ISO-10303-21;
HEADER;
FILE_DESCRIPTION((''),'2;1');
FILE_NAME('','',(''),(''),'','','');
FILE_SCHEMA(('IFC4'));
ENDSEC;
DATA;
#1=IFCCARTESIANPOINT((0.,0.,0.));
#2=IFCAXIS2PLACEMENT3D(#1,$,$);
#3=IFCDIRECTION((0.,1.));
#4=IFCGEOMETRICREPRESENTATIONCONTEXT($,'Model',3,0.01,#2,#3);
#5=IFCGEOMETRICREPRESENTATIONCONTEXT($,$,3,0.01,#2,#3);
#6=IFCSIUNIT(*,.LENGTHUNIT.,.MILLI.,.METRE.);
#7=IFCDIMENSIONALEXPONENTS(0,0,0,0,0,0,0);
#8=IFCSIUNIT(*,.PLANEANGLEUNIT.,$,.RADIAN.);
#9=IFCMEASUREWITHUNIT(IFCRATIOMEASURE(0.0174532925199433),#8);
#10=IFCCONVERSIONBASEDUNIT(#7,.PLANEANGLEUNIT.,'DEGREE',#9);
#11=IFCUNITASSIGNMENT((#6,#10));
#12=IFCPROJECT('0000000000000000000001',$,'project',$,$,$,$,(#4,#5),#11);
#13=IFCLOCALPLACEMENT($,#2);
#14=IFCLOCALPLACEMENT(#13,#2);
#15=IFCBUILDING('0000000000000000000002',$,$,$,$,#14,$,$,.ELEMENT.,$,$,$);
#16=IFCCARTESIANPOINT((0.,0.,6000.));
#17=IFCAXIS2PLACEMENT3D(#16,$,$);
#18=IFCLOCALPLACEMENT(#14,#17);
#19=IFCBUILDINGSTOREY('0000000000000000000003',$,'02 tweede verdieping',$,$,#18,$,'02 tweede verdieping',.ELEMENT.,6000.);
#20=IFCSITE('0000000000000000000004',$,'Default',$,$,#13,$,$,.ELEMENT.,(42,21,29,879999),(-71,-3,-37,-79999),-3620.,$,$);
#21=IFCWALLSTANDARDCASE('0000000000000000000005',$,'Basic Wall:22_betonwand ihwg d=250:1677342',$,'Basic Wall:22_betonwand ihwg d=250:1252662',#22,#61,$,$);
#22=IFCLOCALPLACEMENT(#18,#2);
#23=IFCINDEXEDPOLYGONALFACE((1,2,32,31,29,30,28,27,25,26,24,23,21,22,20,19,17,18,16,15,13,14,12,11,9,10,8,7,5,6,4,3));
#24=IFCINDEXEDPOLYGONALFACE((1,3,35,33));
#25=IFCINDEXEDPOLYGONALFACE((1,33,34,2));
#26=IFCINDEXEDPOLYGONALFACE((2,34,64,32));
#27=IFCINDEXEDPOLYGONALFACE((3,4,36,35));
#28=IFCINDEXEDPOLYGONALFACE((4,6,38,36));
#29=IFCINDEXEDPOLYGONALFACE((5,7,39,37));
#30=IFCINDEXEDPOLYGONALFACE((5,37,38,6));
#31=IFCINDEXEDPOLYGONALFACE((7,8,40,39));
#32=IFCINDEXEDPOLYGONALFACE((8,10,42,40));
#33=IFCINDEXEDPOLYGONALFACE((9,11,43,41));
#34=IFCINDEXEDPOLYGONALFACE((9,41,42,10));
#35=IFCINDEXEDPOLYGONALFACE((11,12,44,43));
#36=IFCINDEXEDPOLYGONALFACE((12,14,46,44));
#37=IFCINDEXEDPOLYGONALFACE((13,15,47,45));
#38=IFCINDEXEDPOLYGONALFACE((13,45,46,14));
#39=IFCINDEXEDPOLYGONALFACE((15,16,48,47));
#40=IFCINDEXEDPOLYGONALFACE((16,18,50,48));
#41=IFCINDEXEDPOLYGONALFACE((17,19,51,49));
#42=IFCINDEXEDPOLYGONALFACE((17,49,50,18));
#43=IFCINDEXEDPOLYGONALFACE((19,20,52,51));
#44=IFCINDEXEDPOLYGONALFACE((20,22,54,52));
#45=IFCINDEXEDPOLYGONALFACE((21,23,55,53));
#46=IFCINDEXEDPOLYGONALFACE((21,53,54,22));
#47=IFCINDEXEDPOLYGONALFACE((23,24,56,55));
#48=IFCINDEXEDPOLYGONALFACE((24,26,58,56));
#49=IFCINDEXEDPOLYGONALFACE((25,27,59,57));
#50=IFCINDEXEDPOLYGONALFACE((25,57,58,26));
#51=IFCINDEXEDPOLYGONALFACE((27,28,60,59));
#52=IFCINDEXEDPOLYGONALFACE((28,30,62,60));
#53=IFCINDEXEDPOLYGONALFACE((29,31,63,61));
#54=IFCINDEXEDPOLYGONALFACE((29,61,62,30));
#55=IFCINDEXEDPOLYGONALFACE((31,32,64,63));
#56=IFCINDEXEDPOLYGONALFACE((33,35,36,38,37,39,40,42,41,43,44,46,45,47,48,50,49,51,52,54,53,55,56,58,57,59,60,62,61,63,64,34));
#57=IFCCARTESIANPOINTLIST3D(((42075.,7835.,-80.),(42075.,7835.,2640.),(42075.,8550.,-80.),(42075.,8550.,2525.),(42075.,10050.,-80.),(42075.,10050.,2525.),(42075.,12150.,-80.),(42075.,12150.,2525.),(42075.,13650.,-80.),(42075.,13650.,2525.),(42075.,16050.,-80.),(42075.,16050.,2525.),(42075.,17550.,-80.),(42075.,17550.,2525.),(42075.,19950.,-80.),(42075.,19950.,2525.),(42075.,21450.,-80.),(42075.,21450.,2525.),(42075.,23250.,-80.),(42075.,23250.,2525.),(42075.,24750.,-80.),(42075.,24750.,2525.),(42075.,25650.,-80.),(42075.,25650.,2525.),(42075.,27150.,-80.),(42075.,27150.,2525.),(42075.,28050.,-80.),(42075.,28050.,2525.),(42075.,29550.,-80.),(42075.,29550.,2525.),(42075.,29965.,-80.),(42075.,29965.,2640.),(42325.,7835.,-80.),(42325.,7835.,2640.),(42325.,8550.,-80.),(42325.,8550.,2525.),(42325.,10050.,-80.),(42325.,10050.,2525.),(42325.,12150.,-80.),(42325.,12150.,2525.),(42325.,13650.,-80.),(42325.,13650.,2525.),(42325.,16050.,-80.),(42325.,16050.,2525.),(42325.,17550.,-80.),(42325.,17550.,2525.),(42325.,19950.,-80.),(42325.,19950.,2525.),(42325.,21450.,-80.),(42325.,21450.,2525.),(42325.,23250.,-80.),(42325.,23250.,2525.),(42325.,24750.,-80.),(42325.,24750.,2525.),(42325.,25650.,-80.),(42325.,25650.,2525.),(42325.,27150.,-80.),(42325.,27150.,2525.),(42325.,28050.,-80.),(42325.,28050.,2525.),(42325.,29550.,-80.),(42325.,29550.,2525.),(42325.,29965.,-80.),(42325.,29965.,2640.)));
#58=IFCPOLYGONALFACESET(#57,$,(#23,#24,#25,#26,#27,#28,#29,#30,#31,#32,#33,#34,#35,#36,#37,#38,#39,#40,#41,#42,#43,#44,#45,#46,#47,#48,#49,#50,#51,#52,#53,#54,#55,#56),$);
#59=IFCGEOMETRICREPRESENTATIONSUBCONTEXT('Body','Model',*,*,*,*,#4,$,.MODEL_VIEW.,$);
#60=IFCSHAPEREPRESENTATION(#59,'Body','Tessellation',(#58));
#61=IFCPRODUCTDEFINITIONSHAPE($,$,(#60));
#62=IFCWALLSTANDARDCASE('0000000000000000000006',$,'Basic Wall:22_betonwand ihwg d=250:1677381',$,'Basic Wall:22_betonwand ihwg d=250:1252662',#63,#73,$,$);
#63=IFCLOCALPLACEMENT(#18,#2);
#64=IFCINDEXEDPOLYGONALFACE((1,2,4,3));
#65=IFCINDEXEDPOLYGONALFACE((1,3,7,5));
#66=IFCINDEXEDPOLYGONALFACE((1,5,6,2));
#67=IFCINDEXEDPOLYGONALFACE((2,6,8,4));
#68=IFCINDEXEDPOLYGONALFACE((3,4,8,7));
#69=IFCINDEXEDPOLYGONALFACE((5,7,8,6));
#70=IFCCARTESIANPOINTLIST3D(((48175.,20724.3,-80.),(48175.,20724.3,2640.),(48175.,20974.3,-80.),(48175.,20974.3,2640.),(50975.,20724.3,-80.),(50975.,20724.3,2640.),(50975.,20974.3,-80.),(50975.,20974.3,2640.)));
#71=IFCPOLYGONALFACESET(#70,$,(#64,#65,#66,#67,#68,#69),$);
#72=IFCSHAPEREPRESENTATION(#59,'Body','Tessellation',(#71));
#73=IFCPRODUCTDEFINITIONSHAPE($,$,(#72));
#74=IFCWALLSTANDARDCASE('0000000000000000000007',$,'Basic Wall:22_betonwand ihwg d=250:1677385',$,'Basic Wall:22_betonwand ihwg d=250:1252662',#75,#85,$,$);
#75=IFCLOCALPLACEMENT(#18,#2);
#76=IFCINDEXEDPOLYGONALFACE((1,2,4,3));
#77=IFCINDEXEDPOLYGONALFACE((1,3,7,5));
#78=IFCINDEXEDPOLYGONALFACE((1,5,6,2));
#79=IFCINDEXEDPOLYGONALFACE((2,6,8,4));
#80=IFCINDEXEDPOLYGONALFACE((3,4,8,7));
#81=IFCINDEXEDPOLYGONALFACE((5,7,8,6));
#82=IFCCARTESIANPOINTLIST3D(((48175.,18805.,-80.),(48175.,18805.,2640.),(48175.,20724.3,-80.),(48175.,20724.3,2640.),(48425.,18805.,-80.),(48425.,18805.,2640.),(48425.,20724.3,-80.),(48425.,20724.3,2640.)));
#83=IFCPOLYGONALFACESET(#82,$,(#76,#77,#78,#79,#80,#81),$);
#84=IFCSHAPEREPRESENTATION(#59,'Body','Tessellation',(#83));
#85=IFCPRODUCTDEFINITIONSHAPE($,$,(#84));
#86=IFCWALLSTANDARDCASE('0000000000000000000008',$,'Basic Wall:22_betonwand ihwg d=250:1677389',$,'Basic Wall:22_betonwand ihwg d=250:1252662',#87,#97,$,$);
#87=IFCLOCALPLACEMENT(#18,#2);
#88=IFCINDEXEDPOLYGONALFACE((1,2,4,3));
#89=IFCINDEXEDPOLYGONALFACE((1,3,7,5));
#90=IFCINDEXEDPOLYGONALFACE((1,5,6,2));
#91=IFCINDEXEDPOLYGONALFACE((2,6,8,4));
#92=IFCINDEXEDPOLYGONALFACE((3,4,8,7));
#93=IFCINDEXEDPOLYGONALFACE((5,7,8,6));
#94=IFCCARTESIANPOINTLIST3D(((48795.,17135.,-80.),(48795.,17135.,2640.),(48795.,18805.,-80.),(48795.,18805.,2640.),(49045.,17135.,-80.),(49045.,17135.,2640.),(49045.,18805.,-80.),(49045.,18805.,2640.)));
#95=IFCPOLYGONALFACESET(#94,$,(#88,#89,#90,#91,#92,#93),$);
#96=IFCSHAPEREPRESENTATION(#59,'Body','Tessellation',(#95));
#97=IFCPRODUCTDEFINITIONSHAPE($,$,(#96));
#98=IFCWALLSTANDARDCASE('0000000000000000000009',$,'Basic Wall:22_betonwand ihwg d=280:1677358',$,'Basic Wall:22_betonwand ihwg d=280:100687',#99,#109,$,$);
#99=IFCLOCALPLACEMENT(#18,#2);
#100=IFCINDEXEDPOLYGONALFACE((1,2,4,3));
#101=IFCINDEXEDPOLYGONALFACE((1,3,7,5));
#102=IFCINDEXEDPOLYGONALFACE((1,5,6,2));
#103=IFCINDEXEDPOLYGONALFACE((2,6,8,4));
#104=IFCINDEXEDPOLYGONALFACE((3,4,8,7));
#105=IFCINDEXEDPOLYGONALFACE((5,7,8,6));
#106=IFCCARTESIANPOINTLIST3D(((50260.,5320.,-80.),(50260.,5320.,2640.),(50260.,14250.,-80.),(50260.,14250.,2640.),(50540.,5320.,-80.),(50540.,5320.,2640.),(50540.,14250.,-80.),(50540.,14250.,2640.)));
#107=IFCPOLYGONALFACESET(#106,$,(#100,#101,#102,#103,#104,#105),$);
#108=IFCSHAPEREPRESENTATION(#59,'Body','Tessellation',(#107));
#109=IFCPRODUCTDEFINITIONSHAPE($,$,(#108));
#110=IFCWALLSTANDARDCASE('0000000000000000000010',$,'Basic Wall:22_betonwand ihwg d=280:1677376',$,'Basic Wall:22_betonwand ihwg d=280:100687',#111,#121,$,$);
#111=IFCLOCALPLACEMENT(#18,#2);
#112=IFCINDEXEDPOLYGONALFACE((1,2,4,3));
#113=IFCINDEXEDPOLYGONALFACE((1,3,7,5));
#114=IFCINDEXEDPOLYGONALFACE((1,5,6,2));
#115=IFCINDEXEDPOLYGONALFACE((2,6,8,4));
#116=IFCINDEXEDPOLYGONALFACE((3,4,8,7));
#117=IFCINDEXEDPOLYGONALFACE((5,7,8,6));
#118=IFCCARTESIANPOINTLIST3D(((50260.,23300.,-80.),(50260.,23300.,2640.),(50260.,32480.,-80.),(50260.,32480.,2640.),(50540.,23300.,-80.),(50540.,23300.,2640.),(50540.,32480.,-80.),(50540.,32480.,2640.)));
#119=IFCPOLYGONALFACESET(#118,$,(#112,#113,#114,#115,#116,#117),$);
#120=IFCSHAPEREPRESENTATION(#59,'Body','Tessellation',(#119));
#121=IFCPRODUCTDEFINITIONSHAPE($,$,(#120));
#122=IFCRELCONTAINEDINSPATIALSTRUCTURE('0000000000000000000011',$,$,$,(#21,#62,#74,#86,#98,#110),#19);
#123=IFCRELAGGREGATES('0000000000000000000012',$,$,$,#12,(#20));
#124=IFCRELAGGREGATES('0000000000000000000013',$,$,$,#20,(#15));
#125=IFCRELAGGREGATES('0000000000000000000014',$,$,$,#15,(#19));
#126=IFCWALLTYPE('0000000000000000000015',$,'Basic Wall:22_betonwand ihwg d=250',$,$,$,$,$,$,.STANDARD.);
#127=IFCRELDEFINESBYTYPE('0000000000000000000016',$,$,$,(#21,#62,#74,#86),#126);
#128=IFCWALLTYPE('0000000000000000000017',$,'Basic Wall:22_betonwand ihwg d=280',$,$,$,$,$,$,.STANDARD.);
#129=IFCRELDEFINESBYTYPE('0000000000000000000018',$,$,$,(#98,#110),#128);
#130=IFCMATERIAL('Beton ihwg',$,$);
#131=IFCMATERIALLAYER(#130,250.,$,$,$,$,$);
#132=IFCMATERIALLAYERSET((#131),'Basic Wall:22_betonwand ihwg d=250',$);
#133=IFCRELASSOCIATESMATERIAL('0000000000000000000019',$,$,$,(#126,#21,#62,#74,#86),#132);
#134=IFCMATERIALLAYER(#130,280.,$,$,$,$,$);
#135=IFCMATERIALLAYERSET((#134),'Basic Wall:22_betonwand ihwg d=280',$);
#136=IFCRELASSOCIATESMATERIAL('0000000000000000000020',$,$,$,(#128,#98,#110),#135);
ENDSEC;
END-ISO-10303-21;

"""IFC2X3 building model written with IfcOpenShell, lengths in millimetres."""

from ifc_helpers import new_model, entity, si_unit, converted_unit, direction, frame, frame_2d, origin, place, context, subcontext, project, spatial, rectangle, extrude, material, layer, layer_set, layer_usage, type_object, element, save


model = new_model("IFC2X3")

# Units and contexts
model_context = context("Model", 3, precision=0.01, world=origin(), true_north=direction((0.0, 1.0)))
context_of_model = context(None, 3, precision=0.01, world=origin(), true_north=direction((0.0, 1.0)))
body_context = subcontext(model_context, "Body", "Model", "MODEL_VIEW")
ifc_project = project(units=[si_unit("LENGTHUNIT", "METRE", prefix="MILLI"), converted_unit("PLANEANGLEUNIT", "DEGREE", entity("IfcRatioMeasure", 0.0174532925199433), si_unit("PLANEANGLEUNIT", "RADIAN"), dimensions=[0, 0, 0, 0, 0, 0, 0])], contexts=[model_context, context_of_model])

# Site, building, storey
site_placement = place(None, origin())
site = spatial("IfcSite", under=ifc_project, at=site_placement, Name="Default", CompositionType="ELEMENT", RefLatitude=(42, 21, 29, 879999), RefLongitude=(-71, -3, -37, -79999), RefElevation=-3620.0)
building_placement = place(site_placement, origin())
building = spatial("IfcBuilding", under=site, at=building_placement, CompositionType="ELEMENT")
storey_placement = place(building_placement, frame((0.0, 0.0, 6000.0)))
storey = spatial("IfcBuildingStorey", under=building, at=storey_placement, Name="02 tweede verdieping", LongName="02 tweede verdieping", CompositionType="ELEMENT", Elevation=6000.0)

# Shared definitions
ifc_material_1 = material(Name="Beton ihwg")

# Wall, openings
ifc_layer_1 = layer(ifc_material_1, 250.0)
ifc_layer_set_1 = layer_set([ifc_layer_1], Name="Basic Wall:22_betonwand ihwg d=250")
ifc_layer_usage_1 = layer_usage(ifc_layer_set_1, "AXIS2", "POSITIVE", -125.0)
wall_type_1 = type_object("IfcWallType", Name="Basic Wall:22_betonwand ihwg d=250", PredefinedType="STANDARD", material=ifc_layer_set_1)
wall_1_placement = place(storey_placement, frame((42200.0, 29965.0, -80.0), z_axis=(0.0, 0.0, 1.0), x_axis=(0.0, -1.0, 0.0)))
wall_1 = element("IfcWallStandardCase", 1, at=wall_1_placement, inside=storey, type_object=wall_type_1, material=ifc_layer_usage_1, Name="Basic Wall:22_betonwand ihwg d=250:1677342", ObjectType="Basic Wall:22_betonwand ihwg d=250:1252662", context=body_context, shape_type="SweptSolid", body=[
    extrude(rectangle(XDim=22130.0, YDim=250.0, at=frame_2d((11065.0, 0.0), x_axis=(-1.0, 0.0))), origin(), (0.0, 0.0, 1.0), 2720.0),
])
opening_1_placement = place(wall_1_placement, frame((29965.0, -42200.0, 80.0), z_axis=(0.0, 0.0, 1.0), x_axis=(0.0, 1.0, 0.0)))
element("IfcOpeningElement", 2, at=opening_1_placement, cuts=wall_1, ObjectType="Opening", context=body_context, shape_type="SweptSolid", body=[
    extrude(rectangle(XDim=2605.0, YDim=1500.0, at=frame_2d((0.0, 0.0), x_axis=(1.0, 0.0))), frame((40801.0, 28800.0, 1222.5), z_axis=(1.0, 0.0, 0.0), x_axis=(0.0, 0.0, -1.0)), (0.0, 0.0, 1.0), 3048.0),
])
opening_2_placement = place(wall_1_placement, frame((29965.0, -42200.0, 80.0), z_axis=(0.0, 0.0, 1.0), x_axis=(0.0, 1.0, 0.0)))
element("IfcOpeningElement", 3, at=opening_2_placement, cuts=wall_1, ObjectType="Opening", context=body_context, shape_type="SweptSolid", body=[
    extrude(rectangle(XDim=2605.0, YDim=1500.0, at=frame_2d((0.0, 0.0), x_axis=(1.0, 0.0))), frame((40801.0, 26400.0, 1222.5), z_axis=(1.0, 0.0, 0.0), x_axis=(0.0, 0.0, -1.0)), (0.0, 0.0, 1.0), 3048.0),
])
opening_3_placement = place(wall_1_placement, frame((29965.0, -42200.0, 80.0), z_axis=(0.0, 0.0, 1.0), x_axis=(0.0, 1.0, 0.0)))
element("IfcOpeningElement", 4, at=opening_3_placement, cuts=wall_1, ObjectType="Opening", context=body_context, shape_type="SweptSolid", body=[
    extrude(rectangle(XDim=2605.0, YDim=1500.0, at=frame_2d((0.0, 0.0), x_axis=(1.0, 0.0))), frame((40801.0, 24000.0, 1222.5), z_axis=(1.0, 0.0, 0.0), x_axis=(0.0, 0.0, -1.0)), (0.0, 0.0, 1.0), 3048.0),
])
opening_4_placement = place(wall_1_placement, frame((29965.0, -42200.0, 80.0), z_axis=(0.0, 0.0, 1.0), x_axis=(0.0, 1.0, 0.0)))
element("IfcOpeningElement", 5, at=opening_4_placement, cuts=wall_1, ObjectType="Opening", context=body_context, shape_type="SweptSolid", body=[
    extrude(rectangle(XDim=2605.0, YDim=1500.0, at=frame_2d((0.0, 0.0), x_axis=(1.0, 0.0))), frame((40801.0, 16800.0, 1222.5), z_axis=(1.0, 0.0, 0.0), x_axis=(0.0, 0.0, -1.0)), (0.0, 0.0, 1.0), 3048.0),
])
opening_5_placement = place(wall_1_placement, frame((29965.0, -42200.0, -2920.0), z_axis=(0.0, 0.0, 1.0), x_axis=(0.0, 1.0, 0.0)))
element("IfcOpeningElement", 6, at=opening_5_placement, cuts=wall_1, ObjectType="Opening", context=body_context, shape_type="SweptSolid", body=[
    extrude(rectangle(XDim=2605.0, YDim=1500.0, at=frame_2d((0.0, 0.0), x_axis=(1.0, 0.0))), frame((40801.0, 9300.0, 4222.5), z_axis=(1.0, 0.0, 0.0), x_axis=(0.0, 0.0, -1.0)), (0.0, 0.0, 1.0), 3048.0),
])
opening_6_placement = place(wall_1_placement, frame((29965.0, -42200.0, 80.0), z_axis=(0.0, 0.0, 1.0), x_axis=(0.0, 1.0, 0.0)))
element("IfcOpeningElement", 7, at=opening_6_placement, cuts=wall_1, ObjectType="Opening", context=body_context, shape_type="SweptSolid", body=[
    extrude(rectangle(XDim=2605.0, YDim=1500.0, at=frame_2d((0.0, 0.0), x_axis=(0.0, 1.0))), frame((40551.0, 12900.0, 1222.5), z_axis=(1.0, 0.0, 0.0), x_axis=(0.0, -1.0, 0.0)), (0.0, 0.0, 1.0), 3048.0),
])
opening_7_placement = place(wall_1_placement, frame((29965.0, -42200.0, 80.0), z_axis=(0.0, 0.0, 1.0), x_axis=(0.0, 1.0, 0.0)))
element("IfcOpeningElement", 8, at=opening_7_placement, cuts=wall_1, ObjectType="Opening", context=body_context, shape_type="SweptSolid", body=[
    extrude(rectangle(XDim=2605.0, YDim=1500.0, at=frame_2d((0.0, 0.0), x_axis=(1.0, 0.0))), frame((40801.0, 20700.0, 1222.5), z_axis=(1.0, 0.0, 0.0), x_axis=(0.0, 0.0, -1.0)), (0.0, 0.0, 1.0), 3048.0),
])

# Walls
ifc_layer_usage_2 = layer_usage(ifc_layer_set_1, "AXIS2", "POSITIVE", -125.0)
wall_2_placement = place(storey_placement, frame((50975.0, 20849.3, -80.0), z_axis=(0.0, 0.0, 1.0), x_axis=(-1.0, 0.0, 0.0)))
element("IfcWallStandardCase", 9, at=wall_2_placement, inside=storey, type_object=wall_type_1, material=ifc_layer_usage_2, Name="Basic Wall:22_betonwand ihwg d=250:1677381", ObjectType="Basic Wall:22_betonwand ihwg d=250:1252662", context=body_context, shape_type="SweptSolid", body=[
    extrude(rectangle(XDim=2800.0, YDim=250.0, at=frame_2d((1400.0, 0.0), x_axis=(-1.0, 0.0))), origin(), (0.0, 0.0, 1.0), 2720.0),
])
ifc_layer_usage_3 = layer_usage(ifc_layer_set_1, "AXIS2", "POSITIVE", -125.0)
wall_3_placement = place(storey_placement, frame((48300.0, 20724.3, -80.0), z_axis=(0.0, 0.0, 1.0), x_axis=(0.0, -1.0, 0.0)))
element("IfcWallStandardCase", 10, at=wall_3_placement, inside=storey, type_object=wall_type_1, material=ifc_layer_usage_3, Name="Basic Wall:22_betonwand ihwg d=250:1677385", ObjectType="Basic Wall:22_betonwand ihwg d=250:1252662", context=body_context, shape_type="SweptSolid", body=[
    extrude(rectangle(XDim=1919.3, YDim=250.0, at=frame_2d((959.6, 0.0), x_axis=(-1.0, 0.0))), origin(), (0.0, 0.0, 1.0), 2720.0),
])
ifc_layer_usage_4 = layer_usage(ifc_layer_set_1, "AXIS2", "POSITIVE", -125.0)
wall_4_placement = place(storey_placement, frame((48920.0, 18805.0, -80.0), z_axis=(0.0, 0.0, 1.0), x_axis=(0.0, -1.0, 0.0)))
element("IfcWallStandardCase", 11, at=wall_4_placement, inside=storey, type_object=wall_type_1, material=ifc_layer_usage_4, Name="Basic Wall:22_betonwand ihwg d=250:1677389", ObjectType="Basic Wall:22_betonwand ihwg d=250:1252662", context=body_context, shape_type="SweptSolid", body=[
    extrude(rectangle(XDim=1670.0, YDim=250.0, at=frame_2d((835.0, 0.0), x_axis=(-1.0, 0.0))), origin(), (0.0, 0.0, 1.0), 2720.0),
])
ifc_layer_2 = layer(ifc_material_1, 280.0)
ifc_layer_set_2 = layer_set([ifc_layer_2], Name="Basic Wall:22_betonwand ihwg d=280")
ifc_layer_usage_5 = layer_usage(ifc_layer_set_2, "AXIS2", "NEGATIVE", 140.0)
wall_type_2 = type_object("IfcWallType", Name="Basic Wall:22_betonwand ihwg d=280", PredefinedType="STANDARD", material=ifc_layer_set_2)
wall_5_placement = place(storey_placement, frame((50400.0, 14250.0, -80.0), z_axis=(0.0, 0.0, 1.0), x_axis=(0.0, -1.0, 0.0)))
element("IfcWallStandardCase", 12, at=wall_5_placement, inside=storey, type_object=wall_type_2, material=ifc_layer_usage_5, Name="Basic Wall:22_betonwand ihwg d=280:1677358", ObjectType="Basic Wall:22_betonwand ihwg d=280:100687", context=body_context, shape_type="SweptSolid", body=[
    extrude(rectangle(XDim=8930.0, YDim=280.0, at=frame_2d((4465.0, 0.0), x_axis=(-1.0, 0.0))), origin(), (0.0, 0.0, 1.0), 2720.0),
])
ifc_layer_usage_6 = layer_usage(ifc_layer_set_2, "AXIS2", "POSITIVE", -140.0)
wall_6_placement = place(storey_placement, frame((50400.0, 23300.0, -80.0), z_axis=(0.0, 0.0, 1.0), x_axis=(0.0, 1.0, 0.0)))
element("IfcWallStandardCase", 13, at=wall_6_placement, inside=storey, type_object=wall_type_2, material=ifc_layer_usage_6, Name="Basic Wall:22_betonwand ihwg d=280:1677376", ObjectType="Basic Wall:22_betonwand ihwg d=280:100687", context=body_context, shape_type="SweptSolid", body=[
    extrude(rectangle(XDim=9180.0, YDim=280.0, at=frame_2d((4590.0, 0.0), x_axis=(-1.0, 0.0))), origin(), (0.0, 0.0, 1.0), 2720.0),
])

save(model, "model.ifc")
